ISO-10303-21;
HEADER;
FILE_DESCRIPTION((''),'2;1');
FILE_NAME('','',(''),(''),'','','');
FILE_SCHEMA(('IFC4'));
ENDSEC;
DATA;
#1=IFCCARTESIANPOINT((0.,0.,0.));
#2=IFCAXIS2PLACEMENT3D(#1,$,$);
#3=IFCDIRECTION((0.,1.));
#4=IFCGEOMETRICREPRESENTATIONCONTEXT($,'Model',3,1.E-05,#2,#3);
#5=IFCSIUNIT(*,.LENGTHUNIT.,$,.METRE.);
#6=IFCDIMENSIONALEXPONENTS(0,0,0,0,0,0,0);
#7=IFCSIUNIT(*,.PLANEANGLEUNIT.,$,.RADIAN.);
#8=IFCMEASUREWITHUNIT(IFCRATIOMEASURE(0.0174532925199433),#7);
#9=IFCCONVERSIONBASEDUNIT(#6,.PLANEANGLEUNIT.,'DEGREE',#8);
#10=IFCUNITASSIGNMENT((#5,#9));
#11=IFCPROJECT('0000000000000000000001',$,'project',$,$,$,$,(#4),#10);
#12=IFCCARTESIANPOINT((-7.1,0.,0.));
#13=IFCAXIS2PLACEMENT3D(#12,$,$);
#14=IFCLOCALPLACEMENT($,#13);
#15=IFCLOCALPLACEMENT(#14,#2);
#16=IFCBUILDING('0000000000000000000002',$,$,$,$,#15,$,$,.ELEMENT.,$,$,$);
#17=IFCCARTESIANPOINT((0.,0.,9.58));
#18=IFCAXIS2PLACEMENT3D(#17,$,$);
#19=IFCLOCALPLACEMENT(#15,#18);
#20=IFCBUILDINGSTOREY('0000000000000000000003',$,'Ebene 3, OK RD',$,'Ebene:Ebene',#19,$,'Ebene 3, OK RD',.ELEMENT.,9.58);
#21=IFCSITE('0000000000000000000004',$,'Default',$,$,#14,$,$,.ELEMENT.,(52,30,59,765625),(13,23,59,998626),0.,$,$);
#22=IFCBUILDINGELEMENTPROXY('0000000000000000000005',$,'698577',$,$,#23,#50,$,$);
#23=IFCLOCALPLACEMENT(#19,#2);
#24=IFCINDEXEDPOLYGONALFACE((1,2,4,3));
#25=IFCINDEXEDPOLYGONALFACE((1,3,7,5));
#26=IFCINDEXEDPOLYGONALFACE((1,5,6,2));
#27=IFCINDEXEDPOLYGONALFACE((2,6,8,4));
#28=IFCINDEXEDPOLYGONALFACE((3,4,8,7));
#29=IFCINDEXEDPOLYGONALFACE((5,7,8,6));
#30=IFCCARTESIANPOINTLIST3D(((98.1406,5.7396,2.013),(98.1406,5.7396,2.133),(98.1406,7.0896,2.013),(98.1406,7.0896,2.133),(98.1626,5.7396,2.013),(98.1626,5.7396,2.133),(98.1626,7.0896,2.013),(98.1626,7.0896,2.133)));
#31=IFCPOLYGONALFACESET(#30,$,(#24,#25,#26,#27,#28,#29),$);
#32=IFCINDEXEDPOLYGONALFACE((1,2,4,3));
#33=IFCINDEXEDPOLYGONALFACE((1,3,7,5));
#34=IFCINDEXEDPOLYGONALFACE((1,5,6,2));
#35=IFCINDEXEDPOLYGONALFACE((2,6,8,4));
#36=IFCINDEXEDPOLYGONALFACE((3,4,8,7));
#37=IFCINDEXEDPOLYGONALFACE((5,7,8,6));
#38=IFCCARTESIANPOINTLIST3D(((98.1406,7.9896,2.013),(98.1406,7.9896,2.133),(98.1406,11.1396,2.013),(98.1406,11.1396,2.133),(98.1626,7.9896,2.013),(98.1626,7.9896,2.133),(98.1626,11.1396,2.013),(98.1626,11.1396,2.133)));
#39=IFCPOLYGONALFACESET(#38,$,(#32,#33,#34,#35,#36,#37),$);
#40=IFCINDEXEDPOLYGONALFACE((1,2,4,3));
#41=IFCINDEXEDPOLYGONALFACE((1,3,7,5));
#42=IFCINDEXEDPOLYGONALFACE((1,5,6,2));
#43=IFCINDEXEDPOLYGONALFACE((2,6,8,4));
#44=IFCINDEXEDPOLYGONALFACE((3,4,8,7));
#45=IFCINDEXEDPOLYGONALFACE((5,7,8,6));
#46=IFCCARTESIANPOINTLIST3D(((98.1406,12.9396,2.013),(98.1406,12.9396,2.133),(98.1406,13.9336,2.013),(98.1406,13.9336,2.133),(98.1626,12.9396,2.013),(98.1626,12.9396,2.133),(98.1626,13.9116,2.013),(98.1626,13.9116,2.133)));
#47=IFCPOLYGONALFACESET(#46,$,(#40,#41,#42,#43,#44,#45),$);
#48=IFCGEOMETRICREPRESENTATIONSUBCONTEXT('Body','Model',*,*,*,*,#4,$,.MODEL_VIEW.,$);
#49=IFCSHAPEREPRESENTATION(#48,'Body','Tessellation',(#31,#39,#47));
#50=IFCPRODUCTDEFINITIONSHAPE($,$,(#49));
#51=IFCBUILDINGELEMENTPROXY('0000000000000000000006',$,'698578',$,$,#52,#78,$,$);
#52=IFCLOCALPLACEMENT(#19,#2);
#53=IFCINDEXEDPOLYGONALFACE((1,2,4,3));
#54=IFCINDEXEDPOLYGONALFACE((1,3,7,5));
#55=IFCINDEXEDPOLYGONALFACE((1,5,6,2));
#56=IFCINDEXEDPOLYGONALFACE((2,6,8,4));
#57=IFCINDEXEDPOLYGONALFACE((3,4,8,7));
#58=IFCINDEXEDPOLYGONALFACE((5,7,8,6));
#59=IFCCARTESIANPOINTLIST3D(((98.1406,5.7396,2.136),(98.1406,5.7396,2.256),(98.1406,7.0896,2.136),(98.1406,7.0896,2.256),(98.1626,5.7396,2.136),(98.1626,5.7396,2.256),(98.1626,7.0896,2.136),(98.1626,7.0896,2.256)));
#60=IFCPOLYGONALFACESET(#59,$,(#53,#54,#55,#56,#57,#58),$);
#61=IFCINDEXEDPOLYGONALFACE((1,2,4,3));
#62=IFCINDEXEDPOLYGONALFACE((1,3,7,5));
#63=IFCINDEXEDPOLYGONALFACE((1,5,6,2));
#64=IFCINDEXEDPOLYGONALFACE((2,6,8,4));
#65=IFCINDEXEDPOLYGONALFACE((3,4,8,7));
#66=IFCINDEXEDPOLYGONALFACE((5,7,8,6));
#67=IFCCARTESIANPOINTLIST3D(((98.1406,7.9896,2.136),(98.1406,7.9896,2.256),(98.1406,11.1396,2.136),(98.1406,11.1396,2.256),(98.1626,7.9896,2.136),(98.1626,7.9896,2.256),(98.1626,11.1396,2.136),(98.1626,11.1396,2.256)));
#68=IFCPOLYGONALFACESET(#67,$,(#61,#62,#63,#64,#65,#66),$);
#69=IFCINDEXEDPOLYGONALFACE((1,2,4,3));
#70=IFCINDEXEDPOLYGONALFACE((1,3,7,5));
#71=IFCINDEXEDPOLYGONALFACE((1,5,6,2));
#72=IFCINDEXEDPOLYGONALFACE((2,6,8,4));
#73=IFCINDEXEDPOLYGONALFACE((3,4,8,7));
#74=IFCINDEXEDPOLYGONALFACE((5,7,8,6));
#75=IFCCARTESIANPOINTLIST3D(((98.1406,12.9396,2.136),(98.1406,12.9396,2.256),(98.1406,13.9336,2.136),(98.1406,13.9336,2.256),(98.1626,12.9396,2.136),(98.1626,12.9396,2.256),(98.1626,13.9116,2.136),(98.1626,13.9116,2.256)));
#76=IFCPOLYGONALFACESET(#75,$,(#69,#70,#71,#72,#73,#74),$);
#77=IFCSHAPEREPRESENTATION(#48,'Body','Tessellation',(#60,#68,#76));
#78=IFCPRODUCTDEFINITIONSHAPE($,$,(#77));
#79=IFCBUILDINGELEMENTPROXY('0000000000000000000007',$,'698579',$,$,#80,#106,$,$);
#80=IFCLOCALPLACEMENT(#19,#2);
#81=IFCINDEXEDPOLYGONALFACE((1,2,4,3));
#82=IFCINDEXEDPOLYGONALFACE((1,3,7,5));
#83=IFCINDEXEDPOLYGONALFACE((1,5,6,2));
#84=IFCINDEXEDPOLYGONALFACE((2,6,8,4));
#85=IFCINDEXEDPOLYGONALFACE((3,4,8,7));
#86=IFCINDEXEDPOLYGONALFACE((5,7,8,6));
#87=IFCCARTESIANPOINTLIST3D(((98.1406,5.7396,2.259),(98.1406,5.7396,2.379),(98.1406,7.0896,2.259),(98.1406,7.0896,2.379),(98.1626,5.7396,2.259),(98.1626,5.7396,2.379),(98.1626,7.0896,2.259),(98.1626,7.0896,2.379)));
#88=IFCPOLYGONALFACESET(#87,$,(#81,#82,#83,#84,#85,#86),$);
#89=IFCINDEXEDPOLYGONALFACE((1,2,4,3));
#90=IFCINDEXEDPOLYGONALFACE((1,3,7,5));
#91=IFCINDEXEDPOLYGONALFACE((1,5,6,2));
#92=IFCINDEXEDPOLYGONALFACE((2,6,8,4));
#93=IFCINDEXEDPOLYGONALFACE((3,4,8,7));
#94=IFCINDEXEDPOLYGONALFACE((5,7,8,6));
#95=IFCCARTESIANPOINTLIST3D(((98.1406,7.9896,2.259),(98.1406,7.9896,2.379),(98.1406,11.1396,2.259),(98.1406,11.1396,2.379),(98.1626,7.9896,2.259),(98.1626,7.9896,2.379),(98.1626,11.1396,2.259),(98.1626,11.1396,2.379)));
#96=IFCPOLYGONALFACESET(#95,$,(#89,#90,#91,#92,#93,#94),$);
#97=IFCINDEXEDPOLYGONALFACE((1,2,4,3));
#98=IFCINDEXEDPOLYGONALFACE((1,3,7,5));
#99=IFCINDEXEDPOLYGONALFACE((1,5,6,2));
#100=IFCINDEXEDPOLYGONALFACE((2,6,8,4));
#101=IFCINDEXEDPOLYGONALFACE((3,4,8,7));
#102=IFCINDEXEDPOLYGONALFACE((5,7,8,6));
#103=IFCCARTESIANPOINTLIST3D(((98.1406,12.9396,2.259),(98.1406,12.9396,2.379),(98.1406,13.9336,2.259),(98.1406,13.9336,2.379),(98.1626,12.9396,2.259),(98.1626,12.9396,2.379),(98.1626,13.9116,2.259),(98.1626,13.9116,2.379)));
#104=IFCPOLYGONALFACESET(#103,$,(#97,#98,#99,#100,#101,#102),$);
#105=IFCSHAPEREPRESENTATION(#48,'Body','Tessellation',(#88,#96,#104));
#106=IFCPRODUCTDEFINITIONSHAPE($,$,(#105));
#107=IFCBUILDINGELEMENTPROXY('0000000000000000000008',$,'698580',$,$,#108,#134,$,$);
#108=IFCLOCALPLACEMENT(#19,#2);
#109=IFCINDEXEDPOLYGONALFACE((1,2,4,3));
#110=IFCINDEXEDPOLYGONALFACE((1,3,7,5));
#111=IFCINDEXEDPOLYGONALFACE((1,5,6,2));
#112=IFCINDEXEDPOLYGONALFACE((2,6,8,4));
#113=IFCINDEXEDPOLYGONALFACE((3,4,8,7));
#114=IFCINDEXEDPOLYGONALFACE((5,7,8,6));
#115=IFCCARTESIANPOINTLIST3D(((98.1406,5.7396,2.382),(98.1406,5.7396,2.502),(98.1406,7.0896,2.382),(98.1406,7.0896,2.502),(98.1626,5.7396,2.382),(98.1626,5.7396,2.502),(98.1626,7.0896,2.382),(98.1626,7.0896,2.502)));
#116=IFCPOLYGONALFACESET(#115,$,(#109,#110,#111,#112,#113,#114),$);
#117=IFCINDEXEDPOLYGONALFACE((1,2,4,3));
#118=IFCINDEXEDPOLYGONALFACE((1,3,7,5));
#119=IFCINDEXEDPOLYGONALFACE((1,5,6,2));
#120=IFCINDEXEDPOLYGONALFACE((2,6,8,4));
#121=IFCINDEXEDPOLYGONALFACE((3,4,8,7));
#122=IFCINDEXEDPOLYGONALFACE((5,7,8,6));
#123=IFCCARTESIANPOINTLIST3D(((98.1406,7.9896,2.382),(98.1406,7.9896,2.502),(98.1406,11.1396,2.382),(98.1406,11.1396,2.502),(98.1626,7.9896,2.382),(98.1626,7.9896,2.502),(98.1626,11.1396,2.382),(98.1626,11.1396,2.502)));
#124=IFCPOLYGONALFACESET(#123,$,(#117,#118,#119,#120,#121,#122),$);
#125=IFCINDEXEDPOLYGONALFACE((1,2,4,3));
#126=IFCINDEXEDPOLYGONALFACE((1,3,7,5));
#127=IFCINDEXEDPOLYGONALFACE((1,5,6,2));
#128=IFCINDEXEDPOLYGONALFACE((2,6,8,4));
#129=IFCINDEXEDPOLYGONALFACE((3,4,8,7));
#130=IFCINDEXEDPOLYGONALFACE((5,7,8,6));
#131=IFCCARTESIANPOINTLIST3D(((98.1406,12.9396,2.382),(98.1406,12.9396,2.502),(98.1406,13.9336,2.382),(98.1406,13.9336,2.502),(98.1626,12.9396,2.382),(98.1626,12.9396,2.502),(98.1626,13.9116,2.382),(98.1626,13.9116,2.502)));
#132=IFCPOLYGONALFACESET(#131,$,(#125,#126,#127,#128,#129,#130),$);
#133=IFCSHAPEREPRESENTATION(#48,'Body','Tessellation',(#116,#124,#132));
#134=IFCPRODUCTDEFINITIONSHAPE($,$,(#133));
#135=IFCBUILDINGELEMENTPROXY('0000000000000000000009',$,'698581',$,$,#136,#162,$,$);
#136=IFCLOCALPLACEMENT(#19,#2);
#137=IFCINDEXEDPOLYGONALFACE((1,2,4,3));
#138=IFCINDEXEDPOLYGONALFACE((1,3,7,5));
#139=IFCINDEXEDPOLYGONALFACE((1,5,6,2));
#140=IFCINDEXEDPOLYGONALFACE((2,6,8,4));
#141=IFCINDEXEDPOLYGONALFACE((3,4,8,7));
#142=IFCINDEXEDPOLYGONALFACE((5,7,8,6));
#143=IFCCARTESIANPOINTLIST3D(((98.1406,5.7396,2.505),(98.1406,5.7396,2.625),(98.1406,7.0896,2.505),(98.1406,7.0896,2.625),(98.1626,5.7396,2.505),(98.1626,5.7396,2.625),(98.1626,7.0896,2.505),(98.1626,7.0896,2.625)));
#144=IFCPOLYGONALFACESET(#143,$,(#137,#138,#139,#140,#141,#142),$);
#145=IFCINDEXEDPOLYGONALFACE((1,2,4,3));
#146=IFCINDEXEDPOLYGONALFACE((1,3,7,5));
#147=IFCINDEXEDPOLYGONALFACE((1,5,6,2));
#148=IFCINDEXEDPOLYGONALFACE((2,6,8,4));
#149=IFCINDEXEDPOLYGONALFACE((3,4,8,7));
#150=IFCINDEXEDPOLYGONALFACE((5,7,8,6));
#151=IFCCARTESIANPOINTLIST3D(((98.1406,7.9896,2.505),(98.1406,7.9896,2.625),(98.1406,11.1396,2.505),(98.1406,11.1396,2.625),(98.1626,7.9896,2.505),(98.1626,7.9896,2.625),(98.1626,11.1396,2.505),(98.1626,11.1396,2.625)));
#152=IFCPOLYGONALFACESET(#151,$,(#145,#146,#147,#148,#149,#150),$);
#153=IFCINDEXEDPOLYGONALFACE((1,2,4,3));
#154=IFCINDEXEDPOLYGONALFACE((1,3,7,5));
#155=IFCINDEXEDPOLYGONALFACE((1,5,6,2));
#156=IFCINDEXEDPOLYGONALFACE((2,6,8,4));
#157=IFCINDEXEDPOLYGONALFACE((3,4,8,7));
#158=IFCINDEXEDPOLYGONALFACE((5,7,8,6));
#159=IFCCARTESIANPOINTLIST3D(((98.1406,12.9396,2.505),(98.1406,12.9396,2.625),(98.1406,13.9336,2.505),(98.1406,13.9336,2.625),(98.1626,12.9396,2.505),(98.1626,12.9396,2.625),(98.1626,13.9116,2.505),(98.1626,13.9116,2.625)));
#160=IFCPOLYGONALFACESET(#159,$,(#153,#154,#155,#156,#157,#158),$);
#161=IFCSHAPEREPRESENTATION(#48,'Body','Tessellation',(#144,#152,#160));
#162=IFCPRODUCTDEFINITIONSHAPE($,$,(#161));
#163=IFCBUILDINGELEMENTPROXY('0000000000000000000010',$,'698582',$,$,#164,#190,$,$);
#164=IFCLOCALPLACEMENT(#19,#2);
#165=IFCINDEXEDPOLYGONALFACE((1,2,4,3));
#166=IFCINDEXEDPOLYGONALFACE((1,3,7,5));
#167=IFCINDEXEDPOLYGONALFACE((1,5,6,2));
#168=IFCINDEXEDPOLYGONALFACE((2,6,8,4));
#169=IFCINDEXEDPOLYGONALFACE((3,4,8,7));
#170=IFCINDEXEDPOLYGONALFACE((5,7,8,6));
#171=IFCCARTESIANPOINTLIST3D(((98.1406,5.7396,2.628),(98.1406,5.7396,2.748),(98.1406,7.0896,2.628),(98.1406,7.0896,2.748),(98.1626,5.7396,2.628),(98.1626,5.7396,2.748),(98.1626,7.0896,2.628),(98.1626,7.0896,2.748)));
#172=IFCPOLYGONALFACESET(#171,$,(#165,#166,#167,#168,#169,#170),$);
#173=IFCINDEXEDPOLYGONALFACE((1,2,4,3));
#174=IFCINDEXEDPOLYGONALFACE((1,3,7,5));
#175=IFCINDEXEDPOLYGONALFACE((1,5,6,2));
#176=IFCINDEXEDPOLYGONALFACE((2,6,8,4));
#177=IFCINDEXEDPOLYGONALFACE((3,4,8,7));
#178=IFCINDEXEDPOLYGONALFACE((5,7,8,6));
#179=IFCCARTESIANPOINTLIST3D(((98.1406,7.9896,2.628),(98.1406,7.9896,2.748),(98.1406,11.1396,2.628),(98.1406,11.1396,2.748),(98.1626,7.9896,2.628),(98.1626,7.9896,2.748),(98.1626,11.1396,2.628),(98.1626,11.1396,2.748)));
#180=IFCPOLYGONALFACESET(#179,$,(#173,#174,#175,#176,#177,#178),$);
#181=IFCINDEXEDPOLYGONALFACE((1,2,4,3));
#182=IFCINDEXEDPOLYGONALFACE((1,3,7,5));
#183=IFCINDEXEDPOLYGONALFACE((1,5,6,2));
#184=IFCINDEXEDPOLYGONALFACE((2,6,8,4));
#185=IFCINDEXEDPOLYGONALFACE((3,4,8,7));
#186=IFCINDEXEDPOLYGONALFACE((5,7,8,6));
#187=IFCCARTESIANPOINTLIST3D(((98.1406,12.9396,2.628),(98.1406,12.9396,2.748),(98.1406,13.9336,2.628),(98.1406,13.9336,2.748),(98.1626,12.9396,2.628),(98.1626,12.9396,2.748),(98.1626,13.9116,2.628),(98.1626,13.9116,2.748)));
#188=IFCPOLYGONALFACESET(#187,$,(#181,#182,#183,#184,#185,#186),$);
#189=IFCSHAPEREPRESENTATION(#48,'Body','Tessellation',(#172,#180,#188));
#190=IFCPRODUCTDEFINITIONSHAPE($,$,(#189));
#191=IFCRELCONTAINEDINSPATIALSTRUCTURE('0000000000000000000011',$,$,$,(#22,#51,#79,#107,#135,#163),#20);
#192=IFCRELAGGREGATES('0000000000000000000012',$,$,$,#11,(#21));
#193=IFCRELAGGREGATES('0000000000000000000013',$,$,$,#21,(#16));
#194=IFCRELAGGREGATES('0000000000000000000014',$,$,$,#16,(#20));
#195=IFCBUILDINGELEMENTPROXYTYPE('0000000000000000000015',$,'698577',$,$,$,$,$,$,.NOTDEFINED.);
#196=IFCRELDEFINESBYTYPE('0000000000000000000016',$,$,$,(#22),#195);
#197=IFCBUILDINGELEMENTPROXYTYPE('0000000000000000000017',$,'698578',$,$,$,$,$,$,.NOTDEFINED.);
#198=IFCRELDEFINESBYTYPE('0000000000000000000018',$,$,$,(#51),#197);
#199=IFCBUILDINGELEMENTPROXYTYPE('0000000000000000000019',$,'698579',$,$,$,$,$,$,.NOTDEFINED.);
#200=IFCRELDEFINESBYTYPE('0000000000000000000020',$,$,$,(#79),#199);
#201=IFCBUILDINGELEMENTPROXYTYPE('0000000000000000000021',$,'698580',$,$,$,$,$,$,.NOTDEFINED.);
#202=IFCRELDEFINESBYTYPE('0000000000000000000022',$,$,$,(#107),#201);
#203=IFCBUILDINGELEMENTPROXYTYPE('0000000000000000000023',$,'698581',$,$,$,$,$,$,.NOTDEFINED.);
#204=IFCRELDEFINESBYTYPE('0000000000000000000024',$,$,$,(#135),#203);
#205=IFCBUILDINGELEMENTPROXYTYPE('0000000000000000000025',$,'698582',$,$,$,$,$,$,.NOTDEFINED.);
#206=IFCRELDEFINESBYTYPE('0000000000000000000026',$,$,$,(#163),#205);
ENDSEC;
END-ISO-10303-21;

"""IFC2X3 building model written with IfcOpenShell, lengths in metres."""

from ifc_helpers import new_model, entity, si_unit, converted_unit, direction, frame, frame_2d, origin, origin_2d_with_axis, place, context, subcontext, project, spatial, polyline, rectangle, outline, extrude, type_object, element, save


model = new_model("IFC2X3")

# Units and contexts
model_context = context("Model", 3, precision=1e-05, world=origin(), true_north=direction((0.0, 1.0)))
body_context = subcontext(model_context, "Body", "Model", "MODEL_VIEW")
ifc_project = project(units=[si_unit("LENGTHUNIT", "METRE"), converted_unit("PLANEANGLEUNIT", "DEGREE", entity("IfcRatioMeasure", 0.0174532925199433), si_unit("PLANEANGLEUNIT", "RADIAN"), dimensions=[0, 0, 0, 0, 0, 0, 0])], contexts=[model_context])

# Site, building, storey
site_placement = place(None, frame((-7.1, 0.0, 0.0)))
site = spatial("IfcSite", under=ifc_project, at=site_placement, Name="Default", CompositionType="ELEMENT", RefLatitude=(52, 30, 59, 765625), RefLongitude=(13, 23, 59, 998626), RefElevation=0.0)
building_placement = place(site_placement, origin())
building = spatial("IfcBuilding", under=site, at=building_placement, CompositionType="ELEMENT")
storey_placement = place(building_placement, frame((0.0, 0.0, 9.58)))
storey = spatial("IfcBuildingStorey", under=building, at=storey_placement, Name="Ebene 3, OK RD", ObjectType="Ebene:Ebene", LongName="Ebene 3, OK RD", CompositionType="ELEMENT", Elevation=9.58)

# Building element proxies
building_element_proxy_type_1 = type_object("IfcBuildingElementProxyType", Name="698577", PredefinedType="NOTDEFINED")
proxy_1_placement = place(storey_placement, origin())
element("IfcBuildingElementProxy", 1, at=proxy_1_placement, inside=storey, type_object=building_element_proxy_type_1, Name="698577", context=body_context, shape_type="SweptSolid", body=[
    extrude(rectangle(XDim=1.35, YDim=0.022, at=frame_2d((0.0, 0.0), x_axis=(1.0, 0.0))), frame((98.1516, 6.4146, 2.013), z_axis=(0.0, 0.0, 1.0), x_axis=(0.0, 1.0, 0.0)), (0.0, 0.0, 1.0), 0.12),
    extrude(rectangle(XDim=3.15, YDim=0.022, at=frame_2d((0.0, 0.0), x_axis=(1.0, 0.0))), frame((98.1516, 9.5646, 2.013), z_axis=(0.0, 0.0, 1.0), x_axis=(0.0, 1.0, 0.0)), (0.0, 0.0, 1.0), 0.12),
    extrude(outline(polyline([(-0.4915, -0.011), (0.4805, -0.011), (0.5025, 0.011), (-0.4915, 0.011), (-0.4915, -0.011)])), frame((98.1516, 13.4311, 2.013), z_axis=(0.0, 0.0, 1.0), x_axis=(0.0, 1.0, 0.0)), (0.0, 0.0, 1.0), 0.12),
])
building_element_proxy_type_2 = type_object("IfcBuildingElementProxyType", Name="698578", PredefinedType="NOTDEFINED")
proxy_2_placement = place(storey_placement, origin())
element("IfcBuildingElementProxy", 2, at=proxy_2_placement, inside=storey, type_object=building_element_proxy_type_2, Name="698578", context=body_context, shape_type="SweptSolid", body=[
    extrude(rectangle(XDim=1.35, YDim=0.022, at=frame_2d((0.0, 0.0), x_axis=(1.0, 0.0))), frame((98.1516, 6.4146, 2.136), z_axis=(0.0, 0.0, 1.0), x_axis=(0.0, 1.0, 0.0)), (0.0, 0.0, 1.0), 0.12),
    extrude(rectangle(XDim=3.15, YDim=0.022, at=origin_2d_with_axis()), frame((98.1516, 9.5646, 2.136), z_axis=(0.0, 0.0, 1.0), x_axis=(0.0, 1.0, 0.0)), (0.0, 0.0, 1.0), 0.12),
    extrude(outline(polyline([(-0.4915, -0.011), (0.4805, -0.011), (0.5025, 0.011), (-0.4915, 0.011), (-0.4915, -0.011)])), frame((98.1516, 13.4311, 2.136), z_axis=(0.0, 0.0, 1.0), x_axis=(0.0, 1.0, 0.0)), (0.0, 0.0, 1.0), 0.12),
])
building_element_proxy_type_3 = type_object("IfcBuildingElementProxyType", Name="698579", PredefinedType="NOTDEFINED")
proxy_3_placement = place(storey_placement, origin())
element("IfcBuildingElementProxy", 3, at=proxy_3_placement, inside=storey, type_object=building_element_proxy_type_3, Name="698579", context=body_context, shape_type="SweptSolid", body=[
    extrude(rectangle(XDim=1.35, YDim=0.022, at=frame_2d((0.0, 0.0), x_axis=(1.0, 0.0))), frame((98.1516, 6.4146, 2.259), z_axis=(0.0, 0.0, 1.0), x_axis=(0.0, 1.0, 0.0)), (0.0, 0.0, 1.0), 0.12),
    extrude(rectangle(XDim=3.15, YDim=0.022, at=origin_2d_with_axis()), frame((98.1516, 9.5646, 2.259), z_axis=(0.0, 0.0, 1.0), x_axis=(0.0, 1.0, 0.0)), (0.0, 0.0, 1.0), 0.12),
    extrude(outline(polyline([(-0.4915, -0.011), (0.4805, -0.011), (0.5025, 0.011), (-0.4915, 0.011), (-0.4915, -0.011)])), frame((98.1516, 13.4311, 2.259), z_axis=(0.0, 0.0, 1.0), x_axis=(0.0, 1.0, 0.0)), (0.0, 0.0, 1.0), 0.12),
])
building_element_proxy_type_4 = type_object("IfcBuildingElementProxyType", Name="698580", PredefinedType="NOTDEFINED")
proxy_4_placement = place(storey_placement, origin())
element("IfcBuildingElementProxy", 4, at=proxy_4_placement, inside=storey, type_object=building_element_proxy_type_4, Name="698580", context=body_context, shape_type="SweptSolid", body=[
    extrude(rectangle(XDim=1.35, YDim=0.022, at=frame_2d((0.0, 0.0), x_axis=(1.0, 0.0))), frame((98.1516, 6.4146, 2.382), z_axis=(0.0, 0.0, 1.0), x_axis=(0.0, 1.0, 0.0)), (0.0, 0.0, 1.0), 0.12),
    extrude(rectangle(XDim=3.15, YDim=0.022, at=origin_2d_with_axis()), frame((98.1516, 9.5646, 2.382), z_axis=(0.0, 0.0, 1.0), x_axis=(0.0, 1.0, 0.0)), (0.0, 0.0, 1.0), 0.12),
    extrude(outline(polyline([(-0.4915, -0.011), (0.4805, -0.011), (0.5025, 0.011), (-0.4915, 0.011), (-0.4915, -0.011)])), frame((98.1516, 13.4311, 2.382), z_axis=(0.0, 0.0, 1.0), x_axis=(0.0, 1.0, 0.0)), (0.0, 0.0, 1.0), 0.12),
])
building_element_proxy_type_5 = type_object("IfcBuildingElementProxyType", Name="698581", PredefinedType="NOTDEFINED")
proxy_5_placement = place(storey_placement, origin())
element("IfcBuildingElementProxy", 5, at=proxy_5_placement, inside=storey, type_object=building_element_proxy_type_5, Name="698581", context=body_context, shape_type="SweptSolid", body=[
    extrude(rectangle(XDim=1.35, YDim=0.022, at=frame_2d((0.0, 0.0), x_axis=(1.0, 0.0))), frame((98.1516, 6.4146, 2.505), z_axis=(0.0, 0.0, 1.0), x_axis=(0.0, 1.0, 0.0)), (0.0, 0.0, 1.0), 0.12),
    extrude(rectangle(XDim=3.15, YDim=0.022, at=origin_2d_with_axis()), frame((98.1516, 9.5646, 2.505), z_axis=(0.0, 0.0, 1.0), x_axis=(0.0, 1.0, 0.0)), (0.0, 0.0, 1.0), 0.12),
    extrude(outline(polyline([(-0.4915, -0.011), (0.4805, -0.011), (0.5025, 0.011), (-0.4915, 0.011), (-0.4915, -0.011)])), frame((98.1516, 13.4311, 2.505), z_axis=(0.0, 0.0, 1.0), x_axis=(0.0, 1.0, 0.0)), (0.0, 0.0, 1.0), 0.12),
])
building_element_proxy_type_6 = type_object("IfcBuildingElementProxyType", Name="698582", PredefinedType="NOTDEFINED")
proxy_6_placement = place(storey_placement, origin())
element("IfcBuildingElementProxy", 6, at=proxy_6_placement, inside=storey, type_object=building_element_proxy_type_6, Name="698582", context=body_context, shape_type="SweptSolid", body=[
    extrude(rectangle(XDim=1.35, YDim=0.022, at=frame_2d((0.0, 0.0), x_axis=(1.0, 0.0))), frame((98.1516, 6.4146, 2.628), z_axis=(0.0, 0.0, 1.0), x_axis=(0.0, 1.0, 0.0)), (0.0, 0.0, 1.0), 0.12),
    extrude(rectangle(XDim=3.15, YDim=0.022, at=frame_2d((0.0, 0.0), x_axis=(1.0, 0.0))), frame((98.1516, 9.5646, 2.628), z_axis=(0.0, 0.0, 1.0), x_axis=(0.0, 1.0, 0.0)), (0.0, 0.0, 1.0), 0.12),
    extrude(outline(polyline([(-0.4915, -0.011), (0.4805, -0.011), (0.5025, 0.011), (-0.4915, 0.011), (-0.4915, -0.011)])), frame((98.1516, 13.4311, 2.628), z_axis=(0.0, 0.0, 1.0), x_axis=(0.0, 1.0, 0.0)), (0.0, 0.0, 1.0), 0.12),
])

save(model, "model.ifc")
